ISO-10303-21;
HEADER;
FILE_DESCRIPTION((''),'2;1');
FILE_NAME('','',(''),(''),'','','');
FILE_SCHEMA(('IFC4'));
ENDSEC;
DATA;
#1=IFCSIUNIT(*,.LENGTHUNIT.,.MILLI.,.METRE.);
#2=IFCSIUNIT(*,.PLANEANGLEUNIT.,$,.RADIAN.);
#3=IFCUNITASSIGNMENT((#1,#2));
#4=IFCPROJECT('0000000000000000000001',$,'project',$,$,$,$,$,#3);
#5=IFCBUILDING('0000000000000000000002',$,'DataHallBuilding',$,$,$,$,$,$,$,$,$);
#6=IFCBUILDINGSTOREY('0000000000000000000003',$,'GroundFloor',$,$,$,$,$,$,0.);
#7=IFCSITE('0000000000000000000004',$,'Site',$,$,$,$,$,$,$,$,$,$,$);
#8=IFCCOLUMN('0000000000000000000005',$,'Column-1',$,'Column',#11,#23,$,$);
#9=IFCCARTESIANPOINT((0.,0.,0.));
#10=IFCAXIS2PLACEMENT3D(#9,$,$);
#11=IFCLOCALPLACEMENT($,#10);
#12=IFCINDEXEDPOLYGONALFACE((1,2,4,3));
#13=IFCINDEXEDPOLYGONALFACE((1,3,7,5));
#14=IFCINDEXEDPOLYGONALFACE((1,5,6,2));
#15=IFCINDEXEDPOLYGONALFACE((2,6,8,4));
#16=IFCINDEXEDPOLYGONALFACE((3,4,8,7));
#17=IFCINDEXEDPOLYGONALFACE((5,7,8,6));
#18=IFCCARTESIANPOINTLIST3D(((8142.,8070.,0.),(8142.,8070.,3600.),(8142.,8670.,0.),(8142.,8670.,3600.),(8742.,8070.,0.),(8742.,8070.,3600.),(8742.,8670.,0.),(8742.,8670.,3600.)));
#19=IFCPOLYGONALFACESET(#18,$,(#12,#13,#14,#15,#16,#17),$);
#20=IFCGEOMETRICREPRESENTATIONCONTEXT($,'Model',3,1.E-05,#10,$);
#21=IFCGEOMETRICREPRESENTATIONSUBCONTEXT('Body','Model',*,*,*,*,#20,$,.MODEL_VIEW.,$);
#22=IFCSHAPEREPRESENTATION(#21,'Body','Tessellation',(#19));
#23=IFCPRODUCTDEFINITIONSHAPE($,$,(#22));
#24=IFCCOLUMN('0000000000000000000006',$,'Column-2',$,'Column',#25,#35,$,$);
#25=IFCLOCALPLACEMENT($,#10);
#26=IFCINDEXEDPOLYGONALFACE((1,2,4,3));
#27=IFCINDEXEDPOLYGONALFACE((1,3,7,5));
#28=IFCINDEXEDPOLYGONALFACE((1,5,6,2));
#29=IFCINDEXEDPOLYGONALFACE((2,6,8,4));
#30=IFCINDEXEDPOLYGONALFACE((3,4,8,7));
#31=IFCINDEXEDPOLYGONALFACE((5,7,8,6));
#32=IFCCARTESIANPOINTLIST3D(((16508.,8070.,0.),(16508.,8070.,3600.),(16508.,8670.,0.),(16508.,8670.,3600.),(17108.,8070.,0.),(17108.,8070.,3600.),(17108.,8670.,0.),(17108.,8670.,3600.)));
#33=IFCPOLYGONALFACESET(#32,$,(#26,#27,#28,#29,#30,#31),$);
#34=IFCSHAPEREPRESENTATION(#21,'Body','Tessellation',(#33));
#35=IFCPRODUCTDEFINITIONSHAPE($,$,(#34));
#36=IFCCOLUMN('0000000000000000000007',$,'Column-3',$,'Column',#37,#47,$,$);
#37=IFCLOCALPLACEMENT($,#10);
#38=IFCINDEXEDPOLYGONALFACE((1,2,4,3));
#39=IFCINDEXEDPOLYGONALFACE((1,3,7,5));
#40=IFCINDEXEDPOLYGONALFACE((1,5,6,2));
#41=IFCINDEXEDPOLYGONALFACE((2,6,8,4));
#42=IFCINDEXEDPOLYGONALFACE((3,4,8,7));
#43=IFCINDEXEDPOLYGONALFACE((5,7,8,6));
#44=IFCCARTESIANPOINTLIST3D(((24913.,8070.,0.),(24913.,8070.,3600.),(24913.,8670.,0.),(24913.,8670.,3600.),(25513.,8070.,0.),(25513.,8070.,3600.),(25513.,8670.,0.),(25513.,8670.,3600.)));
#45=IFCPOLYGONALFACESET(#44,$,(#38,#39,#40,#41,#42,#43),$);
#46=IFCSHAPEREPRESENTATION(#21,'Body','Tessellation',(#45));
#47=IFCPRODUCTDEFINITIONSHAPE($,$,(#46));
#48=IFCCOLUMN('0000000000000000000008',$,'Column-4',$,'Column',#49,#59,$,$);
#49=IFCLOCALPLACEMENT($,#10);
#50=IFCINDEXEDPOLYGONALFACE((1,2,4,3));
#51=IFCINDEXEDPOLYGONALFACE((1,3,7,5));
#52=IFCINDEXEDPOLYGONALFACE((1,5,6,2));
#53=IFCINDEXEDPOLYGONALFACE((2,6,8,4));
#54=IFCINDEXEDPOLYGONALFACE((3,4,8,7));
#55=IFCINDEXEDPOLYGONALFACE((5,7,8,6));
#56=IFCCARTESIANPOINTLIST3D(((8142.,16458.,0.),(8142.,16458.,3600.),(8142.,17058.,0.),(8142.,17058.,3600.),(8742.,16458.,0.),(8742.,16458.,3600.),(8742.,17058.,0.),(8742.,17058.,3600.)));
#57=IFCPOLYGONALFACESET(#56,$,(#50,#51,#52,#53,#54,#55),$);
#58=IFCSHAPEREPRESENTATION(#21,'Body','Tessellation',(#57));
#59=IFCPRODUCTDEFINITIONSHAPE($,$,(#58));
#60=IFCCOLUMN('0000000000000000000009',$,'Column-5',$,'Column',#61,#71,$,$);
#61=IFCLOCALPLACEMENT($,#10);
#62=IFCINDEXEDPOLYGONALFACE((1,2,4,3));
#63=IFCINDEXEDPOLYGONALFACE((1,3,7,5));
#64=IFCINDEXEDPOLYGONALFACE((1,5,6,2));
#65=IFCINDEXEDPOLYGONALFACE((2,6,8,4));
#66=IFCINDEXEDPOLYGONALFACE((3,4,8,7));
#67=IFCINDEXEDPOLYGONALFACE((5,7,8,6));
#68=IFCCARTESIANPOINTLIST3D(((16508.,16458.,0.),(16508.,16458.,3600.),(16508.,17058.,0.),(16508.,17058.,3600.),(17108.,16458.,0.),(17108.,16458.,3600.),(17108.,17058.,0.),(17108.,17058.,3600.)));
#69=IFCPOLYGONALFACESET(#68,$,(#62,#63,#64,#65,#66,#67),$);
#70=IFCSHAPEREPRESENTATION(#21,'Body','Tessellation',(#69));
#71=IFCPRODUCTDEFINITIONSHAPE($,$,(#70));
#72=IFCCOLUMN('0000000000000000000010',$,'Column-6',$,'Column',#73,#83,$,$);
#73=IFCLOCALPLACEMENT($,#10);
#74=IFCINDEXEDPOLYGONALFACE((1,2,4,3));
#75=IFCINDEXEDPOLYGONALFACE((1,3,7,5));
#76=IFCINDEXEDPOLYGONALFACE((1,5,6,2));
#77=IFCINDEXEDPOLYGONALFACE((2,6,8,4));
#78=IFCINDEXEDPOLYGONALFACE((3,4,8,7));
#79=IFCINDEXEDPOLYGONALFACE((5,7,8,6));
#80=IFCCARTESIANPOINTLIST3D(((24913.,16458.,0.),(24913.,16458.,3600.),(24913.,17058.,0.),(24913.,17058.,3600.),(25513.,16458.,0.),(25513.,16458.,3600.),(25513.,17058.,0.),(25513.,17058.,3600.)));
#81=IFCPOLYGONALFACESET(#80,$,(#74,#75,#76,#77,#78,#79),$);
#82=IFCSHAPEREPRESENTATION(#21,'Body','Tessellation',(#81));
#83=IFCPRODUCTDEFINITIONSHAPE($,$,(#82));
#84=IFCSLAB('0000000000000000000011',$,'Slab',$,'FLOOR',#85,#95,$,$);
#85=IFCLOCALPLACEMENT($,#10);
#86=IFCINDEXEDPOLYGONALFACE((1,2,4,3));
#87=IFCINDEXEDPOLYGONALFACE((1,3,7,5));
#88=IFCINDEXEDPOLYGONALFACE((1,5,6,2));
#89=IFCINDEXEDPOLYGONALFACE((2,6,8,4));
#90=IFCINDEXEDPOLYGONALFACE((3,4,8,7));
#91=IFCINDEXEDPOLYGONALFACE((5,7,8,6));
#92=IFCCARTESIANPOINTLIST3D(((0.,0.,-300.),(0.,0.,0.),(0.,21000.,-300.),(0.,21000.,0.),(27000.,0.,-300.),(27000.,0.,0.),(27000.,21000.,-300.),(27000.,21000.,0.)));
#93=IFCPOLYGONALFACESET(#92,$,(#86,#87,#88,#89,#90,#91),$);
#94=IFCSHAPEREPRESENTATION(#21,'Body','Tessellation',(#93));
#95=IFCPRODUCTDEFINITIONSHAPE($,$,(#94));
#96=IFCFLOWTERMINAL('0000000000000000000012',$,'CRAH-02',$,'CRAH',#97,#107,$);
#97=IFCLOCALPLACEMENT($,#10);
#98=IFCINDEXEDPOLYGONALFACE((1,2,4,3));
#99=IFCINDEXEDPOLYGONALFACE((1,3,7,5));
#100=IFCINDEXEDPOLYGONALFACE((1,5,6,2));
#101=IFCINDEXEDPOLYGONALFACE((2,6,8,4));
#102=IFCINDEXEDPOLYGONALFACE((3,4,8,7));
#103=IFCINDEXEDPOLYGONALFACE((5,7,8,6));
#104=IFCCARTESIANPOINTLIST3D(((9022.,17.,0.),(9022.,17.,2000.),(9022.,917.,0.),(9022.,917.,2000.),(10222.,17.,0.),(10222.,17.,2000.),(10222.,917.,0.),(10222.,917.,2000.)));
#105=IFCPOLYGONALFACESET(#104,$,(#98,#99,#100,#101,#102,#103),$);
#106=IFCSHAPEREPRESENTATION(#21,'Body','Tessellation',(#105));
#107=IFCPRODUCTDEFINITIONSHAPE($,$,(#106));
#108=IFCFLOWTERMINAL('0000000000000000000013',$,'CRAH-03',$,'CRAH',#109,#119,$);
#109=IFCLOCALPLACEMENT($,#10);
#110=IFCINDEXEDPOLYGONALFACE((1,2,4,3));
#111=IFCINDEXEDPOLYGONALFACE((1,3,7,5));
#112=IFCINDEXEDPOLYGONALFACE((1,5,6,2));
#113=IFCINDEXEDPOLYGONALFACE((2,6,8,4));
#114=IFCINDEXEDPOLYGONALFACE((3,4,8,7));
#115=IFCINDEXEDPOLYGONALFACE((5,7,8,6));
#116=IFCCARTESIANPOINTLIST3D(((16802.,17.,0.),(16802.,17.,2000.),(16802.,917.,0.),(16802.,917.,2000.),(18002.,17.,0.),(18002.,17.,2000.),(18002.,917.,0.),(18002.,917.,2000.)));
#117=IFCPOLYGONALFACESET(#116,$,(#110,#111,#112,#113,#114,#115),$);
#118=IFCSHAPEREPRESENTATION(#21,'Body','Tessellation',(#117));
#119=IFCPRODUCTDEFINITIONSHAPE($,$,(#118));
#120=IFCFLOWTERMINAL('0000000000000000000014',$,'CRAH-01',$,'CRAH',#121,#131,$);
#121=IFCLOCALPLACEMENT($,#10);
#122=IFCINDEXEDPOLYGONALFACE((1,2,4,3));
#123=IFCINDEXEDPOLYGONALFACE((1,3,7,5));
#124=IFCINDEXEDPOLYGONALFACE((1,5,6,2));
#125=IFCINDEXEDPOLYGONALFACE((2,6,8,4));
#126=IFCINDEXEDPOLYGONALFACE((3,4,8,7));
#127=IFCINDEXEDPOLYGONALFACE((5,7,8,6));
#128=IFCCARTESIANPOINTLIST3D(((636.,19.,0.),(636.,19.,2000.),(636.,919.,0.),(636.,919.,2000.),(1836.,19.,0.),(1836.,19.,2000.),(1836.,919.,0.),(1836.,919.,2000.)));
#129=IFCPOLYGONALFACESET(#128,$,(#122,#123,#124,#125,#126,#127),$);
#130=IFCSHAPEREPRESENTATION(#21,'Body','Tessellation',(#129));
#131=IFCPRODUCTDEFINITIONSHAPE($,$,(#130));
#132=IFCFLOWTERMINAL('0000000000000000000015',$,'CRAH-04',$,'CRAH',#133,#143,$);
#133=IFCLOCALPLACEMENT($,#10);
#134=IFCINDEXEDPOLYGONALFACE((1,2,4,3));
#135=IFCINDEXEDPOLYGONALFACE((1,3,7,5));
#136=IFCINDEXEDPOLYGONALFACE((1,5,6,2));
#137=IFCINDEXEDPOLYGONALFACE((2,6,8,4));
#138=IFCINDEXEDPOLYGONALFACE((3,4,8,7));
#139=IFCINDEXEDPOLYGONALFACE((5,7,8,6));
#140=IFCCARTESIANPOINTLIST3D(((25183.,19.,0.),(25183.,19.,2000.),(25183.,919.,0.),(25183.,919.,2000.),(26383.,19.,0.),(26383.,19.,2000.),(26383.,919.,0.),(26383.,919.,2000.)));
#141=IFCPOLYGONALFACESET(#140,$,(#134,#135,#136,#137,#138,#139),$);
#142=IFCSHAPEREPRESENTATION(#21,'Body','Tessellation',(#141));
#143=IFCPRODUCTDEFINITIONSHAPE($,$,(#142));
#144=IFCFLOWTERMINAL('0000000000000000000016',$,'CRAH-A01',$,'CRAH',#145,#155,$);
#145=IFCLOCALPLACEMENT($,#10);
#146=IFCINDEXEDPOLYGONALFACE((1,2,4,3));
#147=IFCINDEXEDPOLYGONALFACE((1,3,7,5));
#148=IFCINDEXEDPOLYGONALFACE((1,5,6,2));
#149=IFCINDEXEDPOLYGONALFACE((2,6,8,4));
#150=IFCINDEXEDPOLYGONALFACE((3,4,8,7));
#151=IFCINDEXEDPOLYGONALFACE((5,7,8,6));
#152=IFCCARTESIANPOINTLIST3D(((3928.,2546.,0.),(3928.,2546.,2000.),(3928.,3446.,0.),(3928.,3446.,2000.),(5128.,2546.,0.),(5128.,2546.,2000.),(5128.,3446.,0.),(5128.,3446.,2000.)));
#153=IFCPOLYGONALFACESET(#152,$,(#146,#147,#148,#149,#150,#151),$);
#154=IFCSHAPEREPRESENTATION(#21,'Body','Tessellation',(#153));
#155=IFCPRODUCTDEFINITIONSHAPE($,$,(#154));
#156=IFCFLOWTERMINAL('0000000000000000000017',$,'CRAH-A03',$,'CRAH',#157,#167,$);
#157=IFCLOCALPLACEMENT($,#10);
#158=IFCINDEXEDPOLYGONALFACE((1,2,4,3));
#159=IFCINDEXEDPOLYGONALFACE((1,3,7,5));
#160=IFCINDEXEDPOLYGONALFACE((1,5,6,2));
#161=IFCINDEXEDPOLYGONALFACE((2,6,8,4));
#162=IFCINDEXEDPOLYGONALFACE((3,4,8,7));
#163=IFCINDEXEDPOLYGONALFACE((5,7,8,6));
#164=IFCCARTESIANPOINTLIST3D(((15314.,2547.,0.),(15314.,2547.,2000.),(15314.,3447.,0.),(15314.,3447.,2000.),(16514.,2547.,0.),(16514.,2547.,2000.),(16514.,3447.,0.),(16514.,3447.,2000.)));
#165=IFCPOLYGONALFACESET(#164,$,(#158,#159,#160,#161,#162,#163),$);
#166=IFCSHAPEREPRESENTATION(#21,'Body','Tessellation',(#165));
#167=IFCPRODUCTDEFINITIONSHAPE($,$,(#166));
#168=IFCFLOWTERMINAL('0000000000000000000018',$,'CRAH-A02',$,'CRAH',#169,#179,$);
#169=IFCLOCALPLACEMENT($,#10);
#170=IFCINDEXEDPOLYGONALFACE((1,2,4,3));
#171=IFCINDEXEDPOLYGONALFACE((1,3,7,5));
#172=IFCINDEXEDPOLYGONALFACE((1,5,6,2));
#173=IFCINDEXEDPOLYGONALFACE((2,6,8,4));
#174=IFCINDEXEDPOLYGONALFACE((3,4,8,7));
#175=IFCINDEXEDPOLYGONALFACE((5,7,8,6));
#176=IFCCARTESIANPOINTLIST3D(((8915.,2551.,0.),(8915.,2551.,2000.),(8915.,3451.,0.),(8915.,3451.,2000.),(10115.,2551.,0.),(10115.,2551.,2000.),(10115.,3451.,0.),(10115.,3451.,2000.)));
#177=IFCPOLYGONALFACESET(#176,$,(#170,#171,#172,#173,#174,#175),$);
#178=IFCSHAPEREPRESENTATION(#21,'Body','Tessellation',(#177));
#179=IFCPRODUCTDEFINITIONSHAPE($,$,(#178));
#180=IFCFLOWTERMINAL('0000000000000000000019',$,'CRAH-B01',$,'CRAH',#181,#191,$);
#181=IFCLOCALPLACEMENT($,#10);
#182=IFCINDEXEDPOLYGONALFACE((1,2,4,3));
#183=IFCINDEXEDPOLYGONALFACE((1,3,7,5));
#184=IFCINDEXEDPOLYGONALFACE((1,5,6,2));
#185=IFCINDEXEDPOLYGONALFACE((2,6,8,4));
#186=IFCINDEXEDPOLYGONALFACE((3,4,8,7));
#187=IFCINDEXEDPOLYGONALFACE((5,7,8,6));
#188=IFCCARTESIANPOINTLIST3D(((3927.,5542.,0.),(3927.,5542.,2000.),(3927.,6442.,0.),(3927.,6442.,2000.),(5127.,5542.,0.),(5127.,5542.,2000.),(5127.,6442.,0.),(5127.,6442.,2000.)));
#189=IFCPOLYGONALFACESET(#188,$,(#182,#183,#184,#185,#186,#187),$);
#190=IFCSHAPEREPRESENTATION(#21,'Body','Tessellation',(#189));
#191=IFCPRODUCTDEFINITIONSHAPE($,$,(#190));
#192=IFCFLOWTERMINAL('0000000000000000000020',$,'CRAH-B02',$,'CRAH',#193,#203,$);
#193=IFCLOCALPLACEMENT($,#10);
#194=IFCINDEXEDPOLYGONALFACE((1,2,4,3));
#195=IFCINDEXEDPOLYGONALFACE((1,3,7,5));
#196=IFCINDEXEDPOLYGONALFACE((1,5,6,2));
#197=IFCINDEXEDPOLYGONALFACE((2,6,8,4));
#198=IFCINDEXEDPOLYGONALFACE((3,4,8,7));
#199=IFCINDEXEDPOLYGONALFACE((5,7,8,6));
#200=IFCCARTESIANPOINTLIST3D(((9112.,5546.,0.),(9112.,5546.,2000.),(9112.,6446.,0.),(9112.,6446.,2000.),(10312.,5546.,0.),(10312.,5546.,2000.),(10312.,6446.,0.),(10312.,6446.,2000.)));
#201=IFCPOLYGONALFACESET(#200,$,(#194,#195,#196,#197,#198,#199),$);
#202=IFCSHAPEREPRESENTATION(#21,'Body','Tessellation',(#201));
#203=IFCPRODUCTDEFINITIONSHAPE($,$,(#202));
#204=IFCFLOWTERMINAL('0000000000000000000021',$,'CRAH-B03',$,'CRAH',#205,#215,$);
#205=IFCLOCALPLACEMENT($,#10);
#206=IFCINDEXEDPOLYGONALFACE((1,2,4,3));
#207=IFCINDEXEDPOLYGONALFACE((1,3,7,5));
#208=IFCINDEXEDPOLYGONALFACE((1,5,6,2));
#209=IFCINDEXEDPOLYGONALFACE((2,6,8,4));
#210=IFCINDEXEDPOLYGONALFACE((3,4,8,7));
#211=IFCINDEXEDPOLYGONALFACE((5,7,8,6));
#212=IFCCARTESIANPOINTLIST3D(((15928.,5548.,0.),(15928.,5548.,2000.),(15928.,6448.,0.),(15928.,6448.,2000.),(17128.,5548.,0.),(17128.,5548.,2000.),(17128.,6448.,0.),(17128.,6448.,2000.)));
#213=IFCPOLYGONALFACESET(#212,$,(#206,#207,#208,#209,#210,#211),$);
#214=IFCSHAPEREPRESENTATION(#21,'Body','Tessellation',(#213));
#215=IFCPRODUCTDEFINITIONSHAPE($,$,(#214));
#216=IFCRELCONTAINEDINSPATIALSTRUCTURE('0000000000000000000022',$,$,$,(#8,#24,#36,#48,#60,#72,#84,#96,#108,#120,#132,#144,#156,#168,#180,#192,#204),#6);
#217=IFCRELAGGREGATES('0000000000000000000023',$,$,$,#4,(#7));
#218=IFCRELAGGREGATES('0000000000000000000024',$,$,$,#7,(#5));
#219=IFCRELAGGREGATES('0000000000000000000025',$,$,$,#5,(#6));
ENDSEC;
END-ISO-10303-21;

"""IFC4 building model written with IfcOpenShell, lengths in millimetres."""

from ifc_helpers import new_model, si_unit, frame, origin, place, context, subcontext, project, spatial, rectangle, extrude, element, save


model = new_model("IFC4")

# Units and contexts
model_context = context("Model", 3, precision=1e-05, world=origin())
body_context = subcontext(model_context, "Body", "Model", "MODEL_VIEW")
ifc_project = project(units=[si_unit("LENGTHUNIT", "METRE", prefix="MILLI"), si_unit("PLANEANGLEUNIT", "RADIAN")])

# Site, building, storey
site = spatial("IfcSite", under=ifc_project, Name="Site")
building = spatial("IfcBuilding", under=site, Name="DataHallBuilding")
storey = spatial("IfcBuildingStorey", under=building, Name="GroundFloor", Elevation=0.0)

# Columns
column_1_placement = place(None, origin())
element("IfcColumn", 1, at=column_1_placement, inside=storey, Name="Column-1", ObjectType="Column", context=body_context, shape_type="SweptSolid", body=[
    extrude(rectangle(XDim=600.0, YDim=600.0), frame((8442.0, 8370.0, 0.0), z_axis=(0.0, 0.0, 1.0), x_axis=(1.0, 0.0, 0.0)), (0.0, 0.0, 1.0), 3600.0),
])
column_2_placement = place(None, origin())
element("IfcColumn", 2, at=column_2_placement, inside=storey, Name="Column-2", ObjectType="Column", context=body_context, shape_type="SweptSolid", body=[
    extrude(rectangle(XDim=600.0, YDim=600.0), frame((16808.0, 8370.0, 0.0), z_axis=(0.0, 0.0, 1.0), x_axis=(1.0, 0.0, 0.0)), (0.0, 0.0, 1.0), 3600.0),
])
column_3_placement = place(None, origin())
element("IfcColumn", 3, at=column_3_placement, inside=storey, Name="Column-3", ObjectType="Column", context=body_context, shape_type="SweptSolid", body=[
    extrude(rectangle(XDim=600.0, YDim=600.0), frame((25213.0, 8370.0, 0.0), z_axis=(0.0, 0.0, 1.0), x_axis=(1.0, 0.0, 0.0)), (0.0, 0.0, 1.0), 3600.0),
])
column_4_placement = place(None, origin())
element("IfcColumn", 4, at=column_4_placement, inside=storey, Name="Column-4", ObjectType="Column", context=body_context, shape_type="SweptSolid", body=[
    extrude(rectangle(XDim=600.0, YDim=600.0), frame((8442.0, 16758.0, 0.0), z_axis=(0.0, 0.0, 1.0), x_axis=(1.0, 0.0, 0.0)), (0.0, 0.0, 1.0), 3600.0),
])
column_5_placement = place(None, origin())
element("IfcColumn", 5, at=column_5_placement, inside=storey, Name="Column-5", ObjectType="Column", context=body_context, shape_type="SweptSolid", body=[
    extrude(rectangle(XDim=600.0, YDim=600.0), frame((16808.0, 16758.0, 0.0), z_axis=(0.0, 0.0, 1.0), x_axis=(1.0, 0.0, 0.0)), (0.0, 0.0, 1.0), 3600.0),
])
column_6_placement = place(None, origin())
element("IfcColumn", 6, at=column_6_placement, inside=storey, Name="Column-6", ObjectType="Column", context=body_context, shape_type="SweptSolid", body=[
    extrude(rectangle(XDim=600.0, YDim=600.0), frame((25213.0, 16758.0, 0.0), z_axis=(0.0, 0.0, 1.0), x_axis=(1.0, 0.0, 0.0)), (0.0, 0.0, 1.0), 3600.0),
])

# Slab
slab_placement = place(None, origin())
element("IfcSlab", 7, at=slab_placement, inside=storey, Name="Slab", ObjectType="FLOOR", context=body_context, shape_type="SweptSolid", body=[
    extrude(rectangle(XDim=27000.0, YDim=21000.0), frame((13500.0, 10500.0, -300.0), z_axis=(0.0, 0.0, 1.0), x_axis=(1.0, 0.0, 0.0)), (0.0, 0.0, 1.0), 300.0),
])

# Flow terminals
flow_terminal_1_placement = place(None, origin())
element("IfcFlowTerminal", 8, at=flow_terminal_1_placement, inside=storey, Name="CRAH-02", ObjectType="CRAH", context=body_context, shape_type="SweptSolid", body=[
    extrude(rectangle(XDim=1200.0, YDim=900.0), frame((9622.0, 467.0, 0.0), z_axis=(0.0, 0.0, 1.0), x_axis=(1.0, 0.0, 0.0)), (0.0, 0.0, 1.0), 2000.0),
])
flow_terminal_2_placement = place(None, origin())
element("IfcFlowTerminal", 9, at=flow_terminal_2_placement, inside=storey, Name="CRAH-03", ObjectType="CRAH", context=body_context, shape_type="SweptSolid", body=[
    extrude(rectangle(XDim=1200.0, YDim=900.0), frame((17402.0, 467.0, 0.0), z_axis=(0.0, 0.0, 1.0), x_axis=(1.0, 0.0, 0.0)), (0.0, 0.0, 1.0), 2000.0),
])
flow_terminal_3_placement = place(None, origin())
element("IfcFlowTerminal", 10, at=flow_terminal_3_placement, inside=storey, Name="CRAH-01", ObjectType="CRAH", context=body_context, shape_type="SweptSolid", body=[
    extrude(rectangle(XDim=1200.0, YDim=900.0), frame((1236.0, 469.0, 0.0), z_axis=(0.0, 0.0, 1.0), x_axis=(1.0, 0.0, 0.0)), (0.0, 0.0, 1.0), 2000.0),
])
flow_terminal_4_placement = place(None, origin())
element("IfcFlowTerminal", 11, at=flow_terminal_4_placement, inside=storey, Name="CRAH-04", ObjectType="CRAH", context=body_context, shape_type="SweptSolid", body=[
    extrude(rectangle(XDim=1200.0, YDim=900.0), frame((25783.0, 469.0, 0.0), z_axis=(0.0, 0.0, 1.0), x_axis=(1.0, 0.0, 0.0)), (0.0, 0.0, 1.0), 2000.0),
])
flow_terminal_5_placement = place(None, origin())
element("IfcFlowTerminal", 12, at=flow_terminal_5_placement, inside=storey, Name="CRAH-A01", ObjectType="CRAH", context=body_context, shape_type="SweptSolid", body=[
    extrude(rectangle(XDim=1200.0, YDim=900.0), frame((4528.0, 2996.0, 0.0), z_axis=(0.0, 0.0, 1.0), x_axis=(1.0, 0.0, 0.0)), (0.0, 0.0, 1.0), 2000.0),
])
flow_terminal_6_placement = place(None, origin())
element("IfcFlowTerminal", 13, at=flow_terminal_6_placement, inside=storey, Name="CRAH-A03", ObjectType="CRAH", context=body_context, shape_type="SweptSolid", body=[
    extrude(rectangle(XDim=1200.0, YDim=900.0), frame((15914.0, 2997.0, 0.0), z_axis=(0.0, 0.0, 1.0), x_axis=(1.0, 0.0, 0.0)), (0.0, 0.0, 1.0), 2000.0),
])
flow_terminal_7_placement = place(None, origin())
element("IfcFlowTerminal", 14, at=flow_terminal_7_placement, inside=storey, Name="CRAH-A02", ObjectType="CRAH", context=body_context, shape_type="SweptSolid", body=[
    extrude(rectangle(XDim=1200.0, YDim=900.0), frame((9515.0, 3001.0, 0.0), z_axis=(0.0, 0.0, 1.0), x_axis=(1.0, 0.0, 0.0)), (0.0, 0.0, 1.0), 2000.0),
])
flow_terminal_8_placement = place(None, origin())
element("IfcFlowTerminal", 15, at=flow_terminal_8_placement, inside=storey, Name="CRAH-B01", ObjectType="CRAH", context=body_context, shape_type="SweptSolid", body=[
    extrude(rectangle(XDim=1200.0, YDim=900.0), frame((4527.0, 5992.0, 0.0), z_axis=(0.0, 0.0, 1.0), x_axis=(1.0, 0.0, 0.0)), (0.0, 0.0, 1.0), 2000.0),
])
flow_terminal_9_placement = place(None, origin())
element("IfcFlowTerminal", 16, at=flow_terminal_9_placement, inside=storey, Name="CRAH-B02", ObjectType="CRAH", context=body_context, shape_type="SweptSolid", body=[
    extrude(rectangle(XDim=1200.0, YDim=900.0), frame((9712.0, 5996.0, 0.0), z_axis=(0.0, 0.0, 1.0), x_axis=(1.0, 0.0, 0.0)), (0.0, 0.0, 1.0), 2000.0),
])
flow_terminal_10_placement = place(None, origin())
element("IfcFlowTerminal", 17, at=flow_terminal_10_placement, inside=storey, Name="CRAH-B03", ObjectType="CRAH", context=body_context, shape_type="SweptSolid", body=[
    extrude(rectangle(XDim=1200.0, YDim=900.0), frame((16528.0, 5998.0, 0.0), z_axis=(0.0, 0.0, 1.0), x_axis=(1.0, 0.0, 0.0)), (0.0, 0.0, 1.0), 2000.0),
])

save(model, "model.ifc")
